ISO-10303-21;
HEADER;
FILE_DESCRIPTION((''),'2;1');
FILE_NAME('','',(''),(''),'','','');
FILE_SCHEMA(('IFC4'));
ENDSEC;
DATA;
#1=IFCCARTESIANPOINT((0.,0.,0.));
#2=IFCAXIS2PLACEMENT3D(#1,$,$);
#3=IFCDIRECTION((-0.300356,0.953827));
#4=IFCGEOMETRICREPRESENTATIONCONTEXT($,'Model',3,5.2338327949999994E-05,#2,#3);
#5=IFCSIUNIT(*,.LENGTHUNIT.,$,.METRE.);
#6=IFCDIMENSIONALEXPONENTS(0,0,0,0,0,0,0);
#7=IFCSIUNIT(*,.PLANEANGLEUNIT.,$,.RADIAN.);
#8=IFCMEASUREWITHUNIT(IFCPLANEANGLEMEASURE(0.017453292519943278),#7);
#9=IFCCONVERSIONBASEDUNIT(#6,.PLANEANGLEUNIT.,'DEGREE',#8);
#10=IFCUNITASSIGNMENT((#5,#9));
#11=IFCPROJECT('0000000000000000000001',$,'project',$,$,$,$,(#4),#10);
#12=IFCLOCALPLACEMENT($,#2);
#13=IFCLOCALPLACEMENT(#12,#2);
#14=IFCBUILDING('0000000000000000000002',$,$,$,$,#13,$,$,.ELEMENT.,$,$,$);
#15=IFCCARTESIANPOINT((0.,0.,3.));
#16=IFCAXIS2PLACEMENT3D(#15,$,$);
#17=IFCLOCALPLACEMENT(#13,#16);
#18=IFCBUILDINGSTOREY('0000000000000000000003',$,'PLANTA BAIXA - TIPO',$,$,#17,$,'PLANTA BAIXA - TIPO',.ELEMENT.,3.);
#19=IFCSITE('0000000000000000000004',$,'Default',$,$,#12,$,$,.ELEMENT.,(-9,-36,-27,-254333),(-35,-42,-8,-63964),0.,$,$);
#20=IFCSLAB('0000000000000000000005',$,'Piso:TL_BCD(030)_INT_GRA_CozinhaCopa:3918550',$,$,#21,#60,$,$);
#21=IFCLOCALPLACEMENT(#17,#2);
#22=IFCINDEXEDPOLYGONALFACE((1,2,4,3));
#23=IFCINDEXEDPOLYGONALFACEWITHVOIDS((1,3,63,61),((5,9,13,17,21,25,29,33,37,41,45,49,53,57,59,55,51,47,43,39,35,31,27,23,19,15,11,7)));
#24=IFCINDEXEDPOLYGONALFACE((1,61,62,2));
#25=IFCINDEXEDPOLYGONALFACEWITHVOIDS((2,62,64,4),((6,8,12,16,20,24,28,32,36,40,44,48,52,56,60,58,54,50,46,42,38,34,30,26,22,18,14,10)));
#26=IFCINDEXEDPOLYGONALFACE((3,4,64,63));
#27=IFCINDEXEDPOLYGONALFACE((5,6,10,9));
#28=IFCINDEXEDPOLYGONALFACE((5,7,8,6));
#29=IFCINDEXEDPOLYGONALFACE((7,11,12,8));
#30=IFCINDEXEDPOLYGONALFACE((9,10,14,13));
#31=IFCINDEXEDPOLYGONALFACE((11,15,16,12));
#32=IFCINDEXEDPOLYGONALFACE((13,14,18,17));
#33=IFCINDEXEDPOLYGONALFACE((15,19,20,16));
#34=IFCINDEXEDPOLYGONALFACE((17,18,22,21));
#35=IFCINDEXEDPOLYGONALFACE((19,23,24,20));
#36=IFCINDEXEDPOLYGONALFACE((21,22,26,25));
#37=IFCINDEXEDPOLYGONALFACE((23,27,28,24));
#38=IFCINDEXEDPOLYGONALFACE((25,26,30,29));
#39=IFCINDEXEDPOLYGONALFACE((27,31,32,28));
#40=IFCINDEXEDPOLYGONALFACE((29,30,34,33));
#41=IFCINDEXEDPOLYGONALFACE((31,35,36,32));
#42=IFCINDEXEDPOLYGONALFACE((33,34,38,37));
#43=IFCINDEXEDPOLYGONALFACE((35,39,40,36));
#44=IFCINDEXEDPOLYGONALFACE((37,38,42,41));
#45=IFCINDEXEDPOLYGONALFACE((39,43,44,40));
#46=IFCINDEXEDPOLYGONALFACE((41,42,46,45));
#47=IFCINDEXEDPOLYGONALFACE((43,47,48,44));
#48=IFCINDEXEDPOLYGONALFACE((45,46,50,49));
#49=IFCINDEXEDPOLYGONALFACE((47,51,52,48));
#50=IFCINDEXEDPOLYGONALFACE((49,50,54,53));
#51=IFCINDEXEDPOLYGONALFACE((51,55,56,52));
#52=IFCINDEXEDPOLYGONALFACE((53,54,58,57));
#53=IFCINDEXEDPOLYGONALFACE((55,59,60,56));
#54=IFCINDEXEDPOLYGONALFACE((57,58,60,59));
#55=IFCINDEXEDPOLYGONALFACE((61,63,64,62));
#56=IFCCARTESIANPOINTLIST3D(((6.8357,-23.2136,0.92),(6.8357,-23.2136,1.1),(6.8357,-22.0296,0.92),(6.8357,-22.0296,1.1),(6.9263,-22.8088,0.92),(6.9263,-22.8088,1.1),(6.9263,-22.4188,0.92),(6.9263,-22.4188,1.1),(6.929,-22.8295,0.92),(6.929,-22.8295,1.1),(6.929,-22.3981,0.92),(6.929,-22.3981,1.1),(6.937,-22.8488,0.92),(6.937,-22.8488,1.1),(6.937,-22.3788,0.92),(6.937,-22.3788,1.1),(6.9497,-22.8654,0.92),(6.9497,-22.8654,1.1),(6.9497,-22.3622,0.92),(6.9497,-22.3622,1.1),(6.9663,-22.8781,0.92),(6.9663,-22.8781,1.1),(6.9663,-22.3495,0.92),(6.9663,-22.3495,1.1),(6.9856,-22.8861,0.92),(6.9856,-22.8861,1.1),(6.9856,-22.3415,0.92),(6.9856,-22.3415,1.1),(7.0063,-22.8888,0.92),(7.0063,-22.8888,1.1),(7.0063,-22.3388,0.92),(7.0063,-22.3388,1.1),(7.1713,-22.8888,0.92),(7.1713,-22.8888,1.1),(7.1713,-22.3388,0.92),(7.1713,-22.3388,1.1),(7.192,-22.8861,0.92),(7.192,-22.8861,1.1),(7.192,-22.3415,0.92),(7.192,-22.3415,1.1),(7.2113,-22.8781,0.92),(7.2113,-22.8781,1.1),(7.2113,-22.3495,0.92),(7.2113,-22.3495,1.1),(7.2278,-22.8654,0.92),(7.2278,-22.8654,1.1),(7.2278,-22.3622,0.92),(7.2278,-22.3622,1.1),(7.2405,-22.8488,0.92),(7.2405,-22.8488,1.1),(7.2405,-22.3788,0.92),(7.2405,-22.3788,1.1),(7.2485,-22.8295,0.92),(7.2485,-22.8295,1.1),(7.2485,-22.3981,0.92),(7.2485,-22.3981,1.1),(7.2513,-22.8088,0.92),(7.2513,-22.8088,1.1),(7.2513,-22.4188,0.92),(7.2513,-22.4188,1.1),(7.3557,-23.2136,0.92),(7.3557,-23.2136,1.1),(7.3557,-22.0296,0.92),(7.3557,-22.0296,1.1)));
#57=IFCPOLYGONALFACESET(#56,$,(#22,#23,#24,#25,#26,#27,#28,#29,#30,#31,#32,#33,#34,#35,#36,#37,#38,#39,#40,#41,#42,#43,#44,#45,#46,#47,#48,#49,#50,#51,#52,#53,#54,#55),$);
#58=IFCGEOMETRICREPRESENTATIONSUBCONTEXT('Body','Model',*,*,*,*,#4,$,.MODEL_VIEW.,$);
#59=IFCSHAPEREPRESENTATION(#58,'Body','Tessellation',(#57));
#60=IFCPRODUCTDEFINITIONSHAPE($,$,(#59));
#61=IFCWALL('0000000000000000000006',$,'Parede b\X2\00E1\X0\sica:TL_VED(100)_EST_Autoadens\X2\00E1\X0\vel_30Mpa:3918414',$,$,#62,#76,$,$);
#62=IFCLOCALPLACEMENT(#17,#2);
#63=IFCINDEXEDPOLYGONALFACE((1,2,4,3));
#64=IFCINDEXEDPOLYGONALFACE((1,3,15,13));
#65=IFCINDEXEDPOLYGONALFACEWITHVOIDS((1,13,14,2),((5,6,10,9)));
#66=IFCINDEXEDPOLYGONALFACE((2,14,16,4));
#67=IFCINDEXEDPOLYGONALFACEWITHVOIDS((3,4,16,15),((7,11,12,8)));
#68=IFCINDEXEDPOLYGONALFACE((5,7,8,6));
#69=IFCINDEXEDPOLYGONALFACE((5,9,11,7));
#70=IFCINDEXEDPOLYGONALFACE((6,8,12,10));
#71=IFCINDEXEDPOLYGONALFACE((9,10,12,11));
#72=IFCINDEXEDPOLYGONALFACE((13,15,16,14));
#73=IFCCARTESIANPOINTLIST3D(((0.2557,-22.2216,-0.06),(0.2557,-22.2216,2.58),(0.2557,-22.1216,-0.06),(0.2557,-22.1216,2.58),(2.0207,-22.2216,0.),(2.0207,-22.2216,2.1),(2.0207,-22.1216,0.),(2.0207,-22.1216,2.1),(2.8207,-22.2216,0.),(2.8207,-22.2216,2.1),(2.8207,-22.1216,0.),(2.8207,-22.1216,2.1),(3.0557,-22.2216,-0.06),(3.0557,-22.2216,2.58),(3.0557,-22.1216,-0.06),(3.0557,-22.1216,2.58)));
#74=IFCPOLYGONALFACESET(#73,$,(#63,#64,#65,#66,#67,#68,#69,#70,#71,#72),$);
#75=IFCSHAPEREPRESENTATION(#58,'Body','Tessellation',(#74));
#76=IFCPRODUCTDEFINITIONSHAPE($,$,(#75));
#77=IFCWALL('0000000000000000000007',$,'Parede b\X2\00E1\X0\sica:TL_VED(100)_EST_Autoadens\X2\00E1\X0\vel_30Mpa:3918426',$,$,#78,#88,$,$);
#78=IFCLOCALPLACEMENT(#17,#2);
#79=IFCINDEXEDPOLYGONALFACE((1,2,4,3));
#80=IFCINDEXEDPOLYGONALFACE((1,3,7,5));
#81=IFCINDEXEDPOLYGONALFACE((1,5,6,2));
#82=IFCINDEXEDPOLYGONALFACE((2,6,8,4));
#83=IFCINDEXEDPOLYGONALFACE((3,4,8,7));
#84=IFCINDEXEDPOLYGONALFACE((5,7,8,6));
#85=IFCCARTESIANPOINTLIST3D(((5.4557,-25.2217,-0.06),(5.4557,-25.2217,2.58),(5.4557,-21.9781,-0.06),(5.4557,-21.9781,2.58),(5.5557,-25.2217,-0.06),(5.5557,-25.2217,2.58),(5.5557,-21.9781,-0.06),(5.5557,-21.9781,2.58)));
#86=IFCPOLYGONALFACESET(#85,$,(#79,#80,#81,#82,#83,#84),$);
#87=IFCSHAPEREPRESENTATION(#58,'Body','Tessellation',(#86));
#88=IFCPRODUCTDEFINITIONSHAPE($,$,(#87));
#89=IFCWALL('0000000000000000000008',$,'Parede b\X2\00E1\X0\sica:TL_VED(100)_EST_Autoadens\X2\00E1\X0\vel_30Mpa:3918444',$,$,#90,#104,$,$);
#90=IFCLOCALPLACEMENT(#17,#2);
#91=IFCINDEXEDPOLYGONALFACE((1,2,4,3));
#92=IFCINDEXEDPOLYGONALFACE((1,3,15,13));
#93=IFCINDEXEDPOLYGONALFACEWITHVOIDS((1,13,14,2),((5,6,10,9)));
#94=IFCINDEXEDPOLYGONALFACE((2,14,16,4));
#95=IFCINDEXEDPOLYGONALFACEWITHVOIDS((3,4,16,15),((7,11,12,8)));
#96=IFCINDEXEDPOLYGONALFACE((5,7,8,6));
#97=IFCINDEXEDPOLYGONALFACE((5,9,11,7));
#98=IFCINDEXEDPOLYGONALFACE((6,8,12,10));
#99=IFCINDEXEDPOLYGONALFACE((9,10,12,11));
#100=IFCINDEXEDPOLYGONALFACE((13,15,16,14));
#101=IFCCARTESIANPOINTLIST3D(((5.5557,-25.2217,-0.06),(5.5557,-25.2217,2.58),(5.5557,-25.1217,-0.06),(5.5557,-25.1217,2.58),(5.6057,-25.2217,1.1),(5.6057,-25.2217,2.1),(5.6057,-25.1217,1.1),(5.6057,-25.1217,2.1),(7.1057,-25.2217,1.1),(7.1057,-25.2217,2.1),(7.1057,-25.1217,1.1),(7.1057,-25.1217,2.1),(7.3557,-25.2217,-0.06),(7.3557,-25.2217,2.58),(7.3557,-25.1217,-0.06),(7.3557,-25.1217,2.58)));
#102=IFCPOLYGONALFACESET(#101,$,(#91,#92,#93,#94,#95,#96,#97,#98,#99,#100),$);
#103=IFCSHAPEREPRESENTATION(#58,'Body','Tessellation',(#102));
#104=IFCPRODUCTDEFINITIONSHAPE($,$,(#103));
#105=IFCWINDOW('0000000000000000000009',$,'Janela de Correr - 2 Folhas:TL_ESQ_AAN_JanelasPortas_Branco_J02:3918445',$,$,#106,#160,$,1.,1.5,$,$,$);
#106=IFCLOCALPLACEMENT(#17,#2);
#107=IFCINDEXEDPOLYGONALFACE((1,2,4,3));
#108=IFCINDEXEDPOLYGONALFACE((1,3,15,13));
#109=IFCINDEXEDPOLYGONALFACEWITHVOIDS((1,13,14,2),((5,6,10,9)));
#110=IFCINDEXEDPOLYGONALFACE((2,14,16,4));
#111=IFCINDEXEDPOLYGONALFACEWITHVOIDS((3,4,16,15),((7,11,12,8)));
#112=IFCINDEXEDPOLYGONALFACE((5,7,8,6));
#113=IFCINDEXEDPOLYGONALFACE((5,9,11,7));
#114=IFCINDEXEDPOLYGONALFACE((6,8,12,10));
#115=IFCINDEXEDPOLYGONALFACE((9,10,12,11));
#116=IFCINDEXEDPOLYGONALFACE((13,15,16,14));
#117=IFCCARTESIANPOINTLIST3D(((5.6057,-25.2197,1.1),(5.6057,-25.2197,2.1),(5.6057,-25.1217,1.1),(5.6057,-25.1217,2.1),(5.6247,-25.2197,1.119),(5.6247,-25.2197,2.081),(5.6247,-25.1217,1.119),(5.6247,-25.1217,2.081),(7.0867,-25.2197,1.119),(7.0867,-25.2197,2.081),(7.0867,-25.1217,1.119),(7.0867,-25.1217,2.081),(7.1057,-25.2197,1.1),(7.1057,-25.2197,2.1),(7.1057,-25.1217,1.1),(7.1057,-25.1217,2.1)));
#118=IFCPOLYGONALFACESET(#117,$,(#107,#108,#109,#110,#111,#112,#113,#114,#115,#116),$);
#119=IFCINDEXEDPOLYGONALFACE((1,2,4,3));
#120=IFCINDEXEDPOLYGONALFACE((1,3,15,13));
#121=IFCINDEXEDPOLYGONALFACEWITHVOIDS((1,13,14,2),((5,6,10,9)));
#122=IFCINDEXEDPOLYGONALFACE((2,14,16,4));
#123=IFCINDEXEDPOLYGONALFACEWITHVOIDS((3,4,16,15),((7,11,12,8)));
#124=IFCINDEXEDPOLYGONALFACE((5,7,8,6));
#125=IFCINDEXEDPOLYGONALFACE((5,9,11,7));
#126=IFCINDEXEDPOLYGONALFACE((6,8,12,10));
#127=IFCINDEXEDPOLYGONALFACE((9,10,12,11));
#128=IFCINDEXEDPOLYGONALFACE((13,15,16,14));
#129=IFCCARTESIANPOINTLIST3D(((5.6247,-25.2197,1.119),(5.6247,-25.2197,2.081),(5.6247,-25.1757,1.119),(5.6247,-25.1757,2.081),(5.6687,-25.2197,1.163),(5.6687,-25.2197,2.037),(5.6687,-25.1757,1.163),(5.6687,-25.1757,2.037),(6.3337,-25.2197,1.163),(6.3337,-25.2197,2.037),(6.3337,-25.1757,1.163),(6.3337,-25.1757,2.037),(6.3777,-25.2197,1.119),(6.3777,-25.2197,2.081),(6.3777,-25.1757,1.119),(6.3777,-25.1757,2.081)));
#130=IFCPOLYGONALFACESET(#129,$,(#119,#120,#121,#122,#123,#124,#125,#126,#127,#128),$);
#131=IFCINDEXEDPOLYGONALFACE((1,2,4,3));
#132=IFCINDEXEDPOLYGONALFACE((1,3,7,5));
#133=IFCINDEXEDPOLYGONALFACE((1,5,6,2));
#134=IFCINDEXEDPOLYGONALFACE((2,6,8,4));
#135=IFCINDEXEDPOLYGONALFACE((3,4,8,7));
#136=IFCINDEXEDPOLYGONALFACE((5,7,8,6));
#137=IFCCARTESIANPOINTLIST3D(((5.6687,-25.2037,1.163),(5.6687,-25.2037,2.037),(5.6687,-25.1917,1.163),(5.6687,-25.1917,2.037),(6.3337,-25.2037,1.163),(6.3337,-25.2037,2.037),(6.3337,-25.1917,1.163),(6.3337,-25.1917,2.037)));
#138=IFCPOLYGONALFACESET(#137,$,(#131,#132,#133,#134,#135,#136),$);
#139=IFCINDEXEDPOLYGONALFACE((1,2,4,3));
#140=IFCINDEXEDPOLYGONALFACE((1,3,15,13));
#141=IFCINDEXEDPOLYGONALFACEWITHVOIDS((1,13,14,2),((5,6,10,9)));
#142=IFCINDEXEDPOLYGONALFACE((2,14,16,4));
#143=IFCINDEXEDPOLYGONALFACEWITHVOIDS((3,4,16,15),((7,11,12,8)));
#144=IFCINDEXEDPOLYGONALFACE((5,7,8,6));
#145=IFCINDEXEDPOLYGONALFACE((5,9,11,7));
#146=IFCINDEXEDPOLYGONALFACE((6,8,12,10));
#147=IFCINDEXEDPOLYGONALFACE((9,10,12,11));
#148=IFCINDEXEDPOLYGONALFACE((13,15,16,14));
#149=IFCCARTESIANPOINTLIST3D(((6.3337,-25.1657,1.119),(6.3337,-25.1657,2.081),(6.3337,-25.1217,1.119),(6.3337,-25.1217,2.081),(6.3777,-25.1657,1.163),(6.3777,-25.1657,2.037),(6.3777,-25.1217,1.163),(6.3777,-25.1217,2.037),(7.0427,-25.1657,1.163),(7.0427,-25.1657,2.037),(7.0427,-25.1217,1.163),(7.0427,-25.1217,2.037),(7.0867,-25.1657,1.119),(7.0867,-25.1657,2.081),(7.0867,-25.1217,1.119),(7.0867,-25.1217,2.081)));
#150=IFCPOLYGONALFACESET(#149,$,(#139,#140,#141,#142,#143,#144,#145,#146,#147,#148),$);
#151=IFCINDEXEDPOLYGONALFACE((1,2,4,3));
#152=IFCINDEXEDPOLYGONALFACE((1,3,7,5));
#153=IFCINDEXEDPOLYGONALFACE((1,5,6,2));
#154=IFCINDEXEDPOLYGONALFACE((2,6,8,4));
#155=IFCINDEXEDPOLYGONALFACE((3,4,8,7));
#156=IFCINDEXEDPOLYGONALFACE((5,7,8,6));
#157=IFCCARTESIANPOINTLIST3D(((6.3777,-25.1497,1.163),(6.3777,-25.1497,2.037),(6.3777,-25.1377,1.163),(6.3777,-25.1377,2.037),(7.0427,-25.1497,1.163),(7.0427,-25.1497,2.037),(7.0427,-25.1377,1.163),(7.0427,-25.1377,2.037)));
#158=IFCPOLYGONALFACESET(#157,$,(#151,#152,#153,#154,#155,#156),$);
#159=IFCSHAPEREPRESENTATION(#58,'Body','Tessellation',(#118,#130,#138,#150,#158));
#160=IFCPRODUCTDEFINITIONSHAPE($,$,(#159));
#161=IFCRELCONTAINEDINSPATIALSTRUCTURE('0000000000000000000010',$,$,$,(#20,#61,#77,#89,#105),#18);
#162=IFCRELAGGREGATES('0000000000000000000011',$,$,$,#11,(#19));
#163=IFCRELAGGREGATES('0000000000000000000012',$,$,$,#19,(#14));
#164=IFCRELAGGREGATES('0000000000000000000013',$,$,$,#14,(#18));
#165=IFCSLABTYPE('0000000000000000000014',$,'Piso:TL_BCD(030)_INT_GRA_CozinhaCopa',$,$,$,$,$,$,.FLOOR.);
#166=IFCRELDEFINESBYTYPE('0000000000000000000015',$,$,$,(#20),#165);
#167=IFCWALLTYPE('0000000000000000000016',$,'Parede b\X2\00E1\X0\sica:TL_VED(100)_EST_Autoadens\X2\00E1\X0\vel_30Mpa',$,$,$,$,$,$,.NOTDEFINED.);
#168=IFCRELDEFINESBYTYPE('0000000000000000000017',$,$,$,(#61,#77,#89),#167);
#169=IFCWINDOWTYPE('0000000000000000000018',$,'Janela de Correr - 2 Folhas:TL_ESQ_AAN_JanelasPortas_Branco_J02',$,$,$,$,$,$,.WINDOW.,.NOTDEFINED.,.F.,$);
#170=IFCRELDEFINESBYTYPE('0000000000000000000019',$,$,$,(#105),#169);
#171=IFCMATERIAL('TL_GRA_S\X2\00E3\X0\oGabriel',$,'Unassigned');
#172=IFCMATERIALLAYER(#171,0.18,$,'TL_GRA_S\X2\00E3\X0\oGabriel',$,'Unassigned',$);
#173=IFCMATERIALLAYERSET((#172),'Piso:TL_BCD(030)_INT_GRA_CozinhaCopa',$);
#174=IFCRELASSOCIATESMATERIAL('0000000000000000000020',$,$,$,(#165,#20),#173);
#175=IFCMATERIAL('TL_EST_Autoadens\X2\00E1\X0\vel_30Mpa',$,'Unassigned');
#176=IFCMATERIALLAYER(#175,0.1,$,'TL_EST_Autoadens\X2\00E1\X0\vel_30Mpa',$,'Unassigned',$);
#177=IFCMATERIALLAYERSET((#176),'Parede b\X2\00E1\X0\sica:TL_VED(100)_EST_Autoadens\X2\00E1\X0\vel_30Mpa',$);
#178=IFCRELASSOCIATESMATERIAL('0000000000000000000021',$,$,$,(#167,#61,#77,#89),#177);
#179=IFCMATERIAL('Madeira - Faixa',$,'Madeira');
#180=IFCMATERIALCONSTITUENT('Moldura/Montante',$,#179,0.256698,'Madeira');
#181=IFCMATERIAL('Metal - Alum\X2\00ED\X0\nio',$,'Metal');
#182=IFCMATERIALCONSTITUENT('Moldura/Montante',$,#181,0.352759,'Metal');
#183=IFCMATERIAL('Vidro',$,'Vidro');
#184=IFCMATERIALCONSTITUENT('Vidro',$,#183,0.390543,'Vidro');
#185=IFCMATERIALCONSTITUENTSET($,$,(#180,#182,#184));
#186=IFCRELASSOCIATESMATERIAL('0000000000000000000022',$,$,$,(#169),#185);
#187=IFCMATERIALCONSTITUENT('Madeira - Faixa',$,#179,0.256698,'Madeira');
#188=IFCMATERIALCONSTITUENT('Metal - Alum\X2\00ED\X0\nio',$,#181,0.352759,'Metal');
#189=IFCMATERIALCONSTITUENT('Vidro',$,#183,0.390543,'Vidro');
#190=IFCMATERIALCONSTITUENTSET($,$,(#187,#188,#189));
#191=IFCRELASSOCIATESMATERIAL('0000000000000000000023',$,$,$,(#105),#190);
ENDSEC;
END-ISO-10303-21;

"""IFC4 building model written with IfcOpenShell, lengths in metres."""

from ifc_helpers import new_model, entity, si_unit, converted_unit, direction, frame, frame_2d, origin, origin_2d_with_axis, place, context, subcontext, project, spatial, polyline, circle_curve, parameter, trimmed, segment, composite_curve, rectangle, outline, extrude, source, transform, mapped, material, layer, layer_set, layer_usage, constituent, constituent_set, type_object, type_shapes, element, fill, save


model = new_model("IFC4")

# Units and contexts
model_context = context("Model", 3, precision=5.2338327949999994e-05, world=origin(), true_north=direction((-0.300356, 0.953827)))
body_context = subcontext(model_context, "Body", "Model", "MODEL_VIEW")
ifc_project = project(units=[si_unit("LENGTHUNIT", "METRE"), converted_unit("PLANEANGLEUNIT", "DEGREE", entity("IfcPlaneAngleMeasure", 0.017453292519943278), si_unit("PLANEANGLEUNIT", "RADIAN"), dimensions=[0, 0, 0, 0, 0, 0, 0])], contexts=[model_context])

# Site, building, storey
site_placement = place(None, origin())
site = spatial("IfcSite", under=ifc_project, at=site_placement, Name="Default", CompositionType="ELEMENT", RefLatitude=(-9, -36, -27, -254333), RefLongitude=(-35, -42, -8, -63964), RefElevation=0.0)
building_placement = place(site_placement, origin())
building = spatial("IfcBuilding", under=site, at=building_placement, CompositionType="ELEMENT")
storey_placement = place(building_placement, frame((0.0, 0.0, 3.0)))
storey = spatial("IfcBuildingStorey", under=building, at=storey_placement, Name="PLANTA BAIXA - TIPO", LongName="PLANTA BAIXA - TIPO", CompositionType="ELEMENT", Elevation=3.0)

# Slab, opening
ifc_material_1 = material(Name="TL_GRA_SãoGabriel", Category="Unassigned")
ifc_layer_1 = layer(ifc_material_1, 0.18, Name="TL_GRA_SãoGabriel", Category="Unassigned")
ifc_layer_set_1 = layer_set([ifc_layer_1], Name="Piso:TL_BCD(030)_INT_GRA_CozinhaCopa")
ifc_layer_usage_1 = layer_usage(ifc_layer_set_1, "AXIS3", "POSITIVE", 0.0)
slab_type = type_object("IfcSlabType", Name="Piso:TL_BCD(030)_INT_GRA_CozinhaCopa", PredefinedType="FLOOR", material=ifc_layer_set_1)
slab_placement = place(storey_placement, frame((6.8357, -23.2136, 0.92)))
slab = element("IfcSlab", 1, at=slab_placement, inside=storey, type_object=slab_type, material=ifc_layer_usage_1, Name="Piso:TL_BCD(030)_INT_GRA_CozinhaCopa:3918550", context=body_context, shape_type="SweptSolid", body=[
    extrude(rectangle(XDim=0.52, YDim=1.184, at=origin_2d_with_axis()), frame((0.26, 0.592, 0.18), z_axis=(0.0, 0.0, -1.0), x_axis=(-1.0, 0.0, 0.0)), (0.0, 0.0, 1.0), 0.18),
])
opening_1_placement = place(slab_placement, frame((-6.8357, 23.2136, 0.18)))
element("IfcOpeningElement", 2, at=opening_1_placement, cuts=slab, PredefinedType="OPENING", context=body_context, shape_type="SweptSolid", body=[
    extrude(outline(composite_curve([segment(trimmed(circle_curve(frame_2d((0.195, -0.0825), x_axis=(1.0, 0.0)), 0.08), [parameter(270.0)], [parameter(0.0)], True, "PARAMETER"), True, "CONTINUOUS"), segment(polyline([(0.275, -0.0825), (0.275, 0.0825)]), True, "CONTINUOUS"), segment(trimmed(circle_curve(frame_2d((0.195, 0.0825), x_axis=(1.0, 0.0)), 0.08), [parameter(0.0)], [parameter(90.0)], True, "PARAMETER"), True, "CONTINUOUS"), segment(polyline([(0.195, 0.1625), (-0.195, 0.1625)]), True, "CONTINUOUS"), segment(trimmed(circle_curve(frame_2d((-0.195, 0.0825), x_axis=(1.0, 0.0)), 0.08), [parameter(90.0)], [parameter(180.0)], True, "PARAMETER"), True, "CONTINUOUS"), segment(polyline([(-0.275, 0.0825), (-0.275, -0.0825)]), True, "CONTINUOUS"), segment(trimmed(circle_curve(frame_2d((-0.195, -0.0825), x_axis=(1.0, 0.0)), 0.08), [parameter(180.0)], [parameter(270.0)], True, "PARAMETER"), True, "CONTINUOUS"), segment(polyline([(-0.195, -0.1625), (0.195, -0.1625)]), True, "CONTINUOUS")], self_intersect=False)), frame((7.0888, -22.6138, -0.21), z_axis=(0.0, 0.0, 1.0), x_axis=(0.0, 1.0, 0.0)), (0.0, 0.0, 1.0), 0.21),
])

# Wall, opening
ifc_material_2 = material(Name="TL_EST_Autoadensável_30Mpa", Category="Unassigned")
ifc_layer_2 = layer(ifc_material_2, 0.1, Name="TL_EST_Autoadensável_30Mpa", Category="Unassigned")
ifc_layer_set_2 = layer_set([ifc_layer_2], Name="Parede básica:TL_VED(100)_EST_Autoadensável_30Mpa")
ifc_layer_usage_2 = layer_usage(ifc_layer_set_2, "AXIS2", "NEGATIVE", 0.05)
wall_type_1 = type_object("IfcWallType", Name="Parede básica:TL_VED(100)_EST_Autoadensável_30Mpa", PredefinedType="NOTDEFINED", material=ifc_layer_set_2)
wall_1_placement = place(storey_placement, frame((3.0557, -22.1716, -0.06), z_axis=(0.0, 0.0, 1.0), x_axis=(-1.0, 0.0, 0.0)))
wall_1 = element("IfcWall", 3, at=wall_1_placement, inside=storey, type_object=wall_type_1, material=ifc_layer_usage_2, Name="Parede básica:TL_VED(100)_EST_Autoadensável_30Mpa:3918414", context=body_context, shape_type="SweptSolid", body=[
    extrude(rectangle(XDim=2.8, YDim=0.1, at=frame_2d((1.4, 0.0), x_axis=(-1.0, 0.0))), origin(), (0.0, 0.0, 1.0), 2.64),
])
opening_2_placement = place(wall_1_placement, frame((0.235, -0.05, 0.06)))
element("IfcOpeningElement", 4, at=opening_2_placement, cuts=wall_1, PredefinedType="OPENING", context=body_context, shape_type="SweptSolid", body=[
    extrude(rectangle(XDim=2.1, YDim=0.8, at=frame_2d((1.05, 0.4), x_axis=(1.0, 0.0))), frame((0.0, 0.0, 0.0), z_axis=(0.0, 1.0, 0.0), x_axis=(0.0, 0.0, 1.0)), (0.0, 0.0, 1.0), 0.1),
])

# Wall
ifc_layer_usage_3 = layer_usage(ifc_layer_set_2, "AXIS2", "POSITIVE", -0.05)
wall_2_placement = place(storey_placement, frame((5.5057, -25.2217, -0.06), z_axis=(0.0, 0.0, 1.0), x_axis=(0.0, 1.0, 0.0)))
element("IfcWall", 5, at=wall_2_placement, inside=storey, type_object=wall_type_1, material=ifc_layer_usage_3, Name="Parede básica:TL_VED(100)_EST_Autoadensável_30Mpa:3918426", context=body_context, shape_type="SweptSolid", body=[
    extrude(rectangle(XDim=3.2437, YDim=0.1, at=frame_2d((1.6218, 0.0), x_axis=(-1.0, 0.0))), origin(), (0.0, 0.0, 1.0), 2.64),
])

# Wall, opening, window
ifc_layer_usage_4 = layer_usage(ifc_layer_set_2, "AXIS2", "POSITIVE", -0.05)
wall_3_placement = place(storey_placement, frame((5.5557, -25.1717, -0.06)))
wall_3 = element("IfcWall", 6, at=wall_3_placement, inside=storey, type_object=wall_type_1, material=ifc_layer_usage_4, Name="Parede básica:TL_VED(100)_EST_Autoadensável_30Mpa:3918444", context=body_context, shape_type="SweptSolid", body=[
    extrude(rectangle(XDim=1.8, YDim=0.1, at=frame_2d((0.9, 0.0), x_axis=(-1.0, 0.0))), origin(), (0.0, 0.0, 1.0), 2.64),
])
opening_3_placement = place(wall_3_placement, frame((1.55, 0.05, 1.16)))
opening_3 = element("IfcOpeningElement", 7, at=opening_3_placement, cuts=wall_3, PredefinedType="OPENING", context=body_context, shape_type="SweptSolid", body=[
    extrude(rectangle(XDim=1.0, YDim=1.5, at=frame_2d((0.5, 0.75), x_axis=(-1.0, 0.0))), frame((0.0, 0.0, 0.0), z_axis=(0.0, -1.0, 0.0), x_axis=(0.0, 0.0, 1.0)), (0.0, 0.0, 1.0), 0.1),
])
ifc_material_3 = material(Name="Madeira - Faixa", Category="Madeira")
ifc_constituent_1 = constituent(ifc_material_3, Name="Madeira - Faixa", Category="Madeira", fraction=0.256698)
ifc_material_4 = material(Name="Metal - Alumínio", Category="Metal")
ifc_constituent_2 = constituent(ifc_material_4, Name="Metal - Alumínio", Category="Metal", fraction=0.352759)
ifc_material_5 = material(Name="Vidro", Category="Vidro")
ifc_constituent_3 = constituent(ifc_material_5, Name="Vidro", Category="Vidro", fraction=0.390543)
ifc_constituent_set_1 = constituent_set(constituents=[ifc_constituent_1, ifc_constituent_2, ifc_constituent_3])
ifc_constituent_4 = constituent(ifc_material_3, Name="Moldura/Montante", Category="Madeira", fraction=0.256698)
ifc_constituent_5 = constituent(ifc_material_4, Name="Moldura/Montante", Category="Metal", fraction=0.352759)
ifc_constituent_6 = constituent(ifc_material_5, Name="Vidro", Category="Vidro", fraction=0.390543)
ifc_constituent_set_2 = constituent_set(constituents=[ifc_constituent_4, ifc_constituent_5, ifc_constituent_6])
window_type_1 = type_object("IfcWindowType", Name="Janela de Correr - 2 Folhas:TL_ESQ_AAN_JanelasPortas_Branco_J02", ParameterTakesPrecedence=False, PartitioningType="NOTDEFINED", PredefinedType="WINDOW", material=ifc_constituent_set_2)
shared_shape_1 = source(origin(), body_context, "Body", "SweptSolid", [
    extrude(outline(polyline([(-0.75, -0.5), (0.75, -0.5), (0.75, 0.5), (-0.75, 0.5), (-0.75, -0.5)]), holes=[polyline([(-0.731, -0.481), (-0.731, 0.481), (0.731, 0.481), (0.731, -0.481), (-0.731, -0.481)])]), frame((0.75, 0.0, 0.5), z_axis=(0.0, 1.0, 0.0), x_axis=(1.0, 0.0, 0.0)), (0.0, 0.0, 1.0), 0.098),
    extrude(outline(polyline([(-0.3765, -0.481), (0.3765, -0.481), (0.3765, 0.481), (-0.3765, 0.481), (-0.3765, -0.481)]), holes=[polyline([(-0.3325, -0.437), (-0.3325, 0.437), (0.3325, 0.437), (0.3325, -0.437), (-0.3325, -0.437)])]), frame((1.1045, 0.054, 0.5), z_axis=(0.0, 1.0, 0.0), x_axis=(1.0, 0.0, 0.0)), (0.0, 0.0, 1.0), 0.044),
    extrude(rectangle(XDim=0.012, YDim=0.665, at=origin_2d_with_axis()), frame((1.1045, 0.076, 0.063), z_axis=(0.0, 0.0, 1.0), x_axis=(0.0, -1.0, 0.0)), (0.0, 0.0, 1.0), 0.874),
    extrude(outline(polyline([(-0.481, -0.3765), (0.481, -0.3765), (0.481, 0.3765), (-0.481, 0.3765), (-0.481, -0.3765)]), holes=[polyline([(-0.437, -0.3325), (-0.437, 0.3325), (0.437, 0.3325), (0.437, -0.3325), (-0.437, -0.3325)])]), frame((0.3955, 0.0, 0.5), z_axis=(0.0, 1.0, 0.0), x_axis=(0.0, 0.0, -1.0)), (0.0, 0.0, 1.0), 0.044),
    extrude(rectangle(XDim=0.012, YDim=0.665, at=origin_2d_with_axis()), frame((0.3955, 0.022, 0.063), z_axis=(0.0, 0.0, 1.0), x_axis=(0.0, -1.0, 0.0)), (0.0, 0.0, 1.0), 0.874),
])
type_shapes(window_type_1, [shared_shape_1])
window_1_placement = place(opening_3_placement, frame((0.0, 0.0, 0.0), z_axis=(0.0, 0.0, 1.0), x_axis=(-1.0, 0.0, 0.0)))
window_1 = element("IfcWindow", 8, at=window_1_placement, inside=storey, type_object=window_type_1, material=ifc_constituent_set_1, Name="Janela de Correr - 2 Folhas:TL_ESQ_AAN_JanelasPortas_Branco_J02:3918445", OverallHeight=1.0, OverallWidth=1.5, context=body_context, shape_type="MappedRepresentation", body=[
    mapped(shared_shape_1, transform((0.0, 0.0, 0.0), scale=1.0)),
])
fill(opening_3, window_1)

save(model, "model.ifc")
